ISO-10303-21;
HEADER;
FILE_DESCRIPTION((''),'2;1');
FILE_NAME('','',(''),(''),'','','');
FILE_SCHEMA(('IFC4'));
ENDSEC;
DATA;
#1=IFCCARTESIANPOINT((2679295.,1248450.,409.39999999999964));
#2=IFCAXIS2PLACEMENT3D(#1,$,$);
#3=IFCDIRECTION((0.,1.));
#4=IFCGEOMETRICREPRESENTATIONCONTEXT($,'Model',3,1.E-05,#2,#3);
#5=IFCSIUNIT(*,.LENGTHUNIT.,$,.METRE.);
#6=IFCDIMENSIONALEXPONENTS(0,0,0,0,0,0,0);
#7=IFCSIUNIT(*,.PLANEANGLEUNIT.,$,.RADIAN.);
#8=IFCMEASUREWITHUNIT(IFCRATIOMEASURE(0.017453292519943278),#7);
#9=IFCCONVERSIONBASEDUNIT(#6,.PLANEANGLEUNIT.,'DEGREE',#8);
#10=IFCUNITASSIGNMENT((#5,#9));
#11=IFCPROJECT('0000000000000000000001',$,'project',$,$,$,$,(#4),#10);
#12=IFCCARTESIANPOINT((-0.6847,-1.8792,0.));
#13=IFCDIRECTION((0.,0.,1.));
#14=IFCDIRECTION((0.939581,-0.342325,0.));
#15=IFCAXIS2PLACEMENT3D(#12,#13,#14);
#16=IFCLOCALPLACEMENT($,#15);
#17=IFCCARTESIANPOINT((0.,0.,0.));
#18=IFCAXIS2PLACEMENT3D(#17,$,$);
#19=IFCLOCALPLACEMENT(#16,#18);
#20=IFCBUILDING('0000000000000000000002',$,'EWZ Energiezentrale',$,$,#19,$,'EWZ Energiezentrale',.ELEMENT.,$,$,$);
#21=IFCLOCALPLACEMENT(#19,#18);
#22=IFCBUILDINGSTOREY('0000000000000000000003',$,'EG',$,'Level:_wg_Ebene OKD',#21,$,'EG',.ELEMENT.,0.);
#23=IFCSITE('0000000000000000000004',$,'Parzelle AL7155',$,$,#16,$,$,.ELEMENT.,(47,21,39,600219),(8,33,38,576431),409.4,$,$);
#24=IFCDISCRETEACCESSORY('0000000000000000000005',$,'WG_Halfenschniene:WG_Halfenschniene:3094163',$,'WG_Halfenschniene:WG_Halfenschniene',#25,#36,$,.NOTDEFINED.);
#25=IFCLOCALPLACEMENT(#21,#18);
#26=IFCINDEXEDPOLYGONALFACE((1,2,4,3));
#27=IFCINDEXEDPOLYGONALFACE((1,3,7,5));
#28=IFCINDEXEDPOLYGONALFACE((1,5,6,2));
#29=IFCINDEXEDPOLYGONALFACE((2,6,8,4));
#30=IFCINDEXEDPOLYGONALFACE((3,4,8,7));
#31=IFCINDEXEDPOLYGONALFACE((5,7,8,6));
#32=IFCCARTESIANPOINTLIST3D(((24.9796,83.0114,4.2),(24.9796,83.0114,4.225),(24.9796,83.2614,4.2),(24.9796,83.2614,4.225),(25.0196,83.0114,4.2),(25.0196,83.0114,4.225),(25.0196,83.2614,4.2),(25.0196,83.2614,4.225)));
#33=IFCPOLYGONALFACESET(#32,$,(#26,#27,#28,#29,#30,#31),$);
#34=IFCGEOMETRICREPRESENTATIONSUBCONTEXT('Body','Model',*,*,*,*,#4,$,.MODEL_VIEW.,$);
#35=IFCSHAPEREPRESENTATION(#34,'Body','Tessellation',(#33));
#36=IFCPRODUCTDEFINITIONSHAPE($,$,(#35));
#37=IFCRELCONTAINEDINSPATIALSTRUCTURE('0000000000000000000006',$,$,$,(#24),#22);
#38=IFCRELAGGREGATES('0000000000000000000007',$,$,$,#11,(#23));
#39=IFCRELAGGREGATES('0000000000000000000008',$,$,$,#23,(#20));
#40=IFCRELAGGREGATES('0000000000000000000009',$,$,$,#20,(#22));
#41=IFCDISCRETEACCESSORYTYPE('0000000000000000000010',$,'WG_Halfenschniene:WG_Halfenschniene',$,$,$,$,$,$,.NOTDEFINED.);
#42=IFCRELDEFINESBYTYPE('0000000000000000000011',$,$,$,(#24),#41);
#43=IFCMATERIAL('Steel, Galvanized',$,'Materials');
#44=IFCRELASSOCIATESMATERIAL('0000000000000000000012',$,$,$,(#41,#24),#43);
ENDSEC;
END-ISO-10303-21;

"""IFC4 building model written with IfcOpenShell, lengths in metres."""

from ifc_helpers import new_model, entity, si_unit, converted_unit, direction, frame, origin, place, context, subcontext, project, spatial, indexed_curve, outline, extrude, source, transform, mapped, material, type_object, element, save


model = new_model("IFC4")

# Units and contexts
model_context = context("Model", 3, precision=1e-05, world=frame((2679295.0, 1248450.0, 409.39999999999964)), true_north=direction((0.0, 1.0)))
body_context = subcontext(model_context, "Body", "Model", "MODEL_VIEW")
ifc_project = project(units=[si_unit("LENGTHUNIT", "METRE"), converted_unit("PLANEANGLEUNIT", "DEGREE", entity("IfcRatioMeasure", 0.017453292519943278), si_unit("PLANEANGLEUNIT", "RADIAN"), dimensions=[0, 0, 0, 0, 0, 0, 0])], contexts=[model_context])

# Site, building, storey
site_placement = place(None, frame((-0.6847, -1.8792, 0.0), z_axis=(0.0, 0.0, 1.0), x_axis=(0.939581, -0.342325, 0.0)))
site = spatial("IfcSite", under=ifc_project, at=site_placement, Name="Parzelle AL7155", CompositionType="ELEMENT", RefLatitude=(47, 21, 39, 600219), RefLongitude=(8, 33, 38, 576431), RefElevation=409.4)
building_placement = place(site_placement, origin())
building = spatial("IfcBuilding", under=site, at=building_placement, Name="EWZ Energiezentrale", LongName="EWZ Energiezentrale", CompositionType="ELEMENT")
storey_placement = place(building_placement, origin())
storey = spatial("IfcBuildingStorey", under=building, at=storey_placement, Name="EG", ObjectType="Level:_wg_Ebene OKD", LongName="EG", CompositionType="ELEMENT", Elevation=0.0)

# Discrete accessory
ifc_material = material(Name="Steel, Galvanized", Category="Materials")
discrete_accessory_type = type_object("IfcDiscreteAccessoryType", Name="WG_Halfenschniene:WG_Halfenschniene", PredefinedType="NOTDEFINED", material=ifc_material)
shared_shape = source(origin(), body_context, "Body", "SweptSolid", [
    extrude(outline(indexed_curve([(-0.125, -0.02), (0.125, -0.02), (0.125, 0.02), (-0.125, 0.02), (-0.125, -0.02)], self_intersect=False)), frame((0.125, 0.0, -0.0125)), (0.0, 0.0, 1.0), 0.025),
])
for number, where, z_axis, x_axis, name in (
    (1, (24.9996, 83.0114, 4.2125), (0.0, 0.0, -1.0), (0.0, 1.0, 0.0), "WG_Halfenschniene:WG_Halfenschniene:3094163"),
):
    element("IfcDiscreteAccessory", number, at=place(storey_placement, frame(where, z_axis=z_axis, x_axis=x_axis)), inside=storey, type_object=discrete_accessory_type, material=ifc_material, Name=name, ObjectType="WG_Halfenschniene:WG_Halfenschniene", PredefinedType="NOTDEFINED", context=body_context, shape_type="MappedRepresentation", body=[
        mapped(shared_shape, transform((0.0, 0.0, 0.0), scale=1.0)),
    ])

save(model, "model.ifc")
